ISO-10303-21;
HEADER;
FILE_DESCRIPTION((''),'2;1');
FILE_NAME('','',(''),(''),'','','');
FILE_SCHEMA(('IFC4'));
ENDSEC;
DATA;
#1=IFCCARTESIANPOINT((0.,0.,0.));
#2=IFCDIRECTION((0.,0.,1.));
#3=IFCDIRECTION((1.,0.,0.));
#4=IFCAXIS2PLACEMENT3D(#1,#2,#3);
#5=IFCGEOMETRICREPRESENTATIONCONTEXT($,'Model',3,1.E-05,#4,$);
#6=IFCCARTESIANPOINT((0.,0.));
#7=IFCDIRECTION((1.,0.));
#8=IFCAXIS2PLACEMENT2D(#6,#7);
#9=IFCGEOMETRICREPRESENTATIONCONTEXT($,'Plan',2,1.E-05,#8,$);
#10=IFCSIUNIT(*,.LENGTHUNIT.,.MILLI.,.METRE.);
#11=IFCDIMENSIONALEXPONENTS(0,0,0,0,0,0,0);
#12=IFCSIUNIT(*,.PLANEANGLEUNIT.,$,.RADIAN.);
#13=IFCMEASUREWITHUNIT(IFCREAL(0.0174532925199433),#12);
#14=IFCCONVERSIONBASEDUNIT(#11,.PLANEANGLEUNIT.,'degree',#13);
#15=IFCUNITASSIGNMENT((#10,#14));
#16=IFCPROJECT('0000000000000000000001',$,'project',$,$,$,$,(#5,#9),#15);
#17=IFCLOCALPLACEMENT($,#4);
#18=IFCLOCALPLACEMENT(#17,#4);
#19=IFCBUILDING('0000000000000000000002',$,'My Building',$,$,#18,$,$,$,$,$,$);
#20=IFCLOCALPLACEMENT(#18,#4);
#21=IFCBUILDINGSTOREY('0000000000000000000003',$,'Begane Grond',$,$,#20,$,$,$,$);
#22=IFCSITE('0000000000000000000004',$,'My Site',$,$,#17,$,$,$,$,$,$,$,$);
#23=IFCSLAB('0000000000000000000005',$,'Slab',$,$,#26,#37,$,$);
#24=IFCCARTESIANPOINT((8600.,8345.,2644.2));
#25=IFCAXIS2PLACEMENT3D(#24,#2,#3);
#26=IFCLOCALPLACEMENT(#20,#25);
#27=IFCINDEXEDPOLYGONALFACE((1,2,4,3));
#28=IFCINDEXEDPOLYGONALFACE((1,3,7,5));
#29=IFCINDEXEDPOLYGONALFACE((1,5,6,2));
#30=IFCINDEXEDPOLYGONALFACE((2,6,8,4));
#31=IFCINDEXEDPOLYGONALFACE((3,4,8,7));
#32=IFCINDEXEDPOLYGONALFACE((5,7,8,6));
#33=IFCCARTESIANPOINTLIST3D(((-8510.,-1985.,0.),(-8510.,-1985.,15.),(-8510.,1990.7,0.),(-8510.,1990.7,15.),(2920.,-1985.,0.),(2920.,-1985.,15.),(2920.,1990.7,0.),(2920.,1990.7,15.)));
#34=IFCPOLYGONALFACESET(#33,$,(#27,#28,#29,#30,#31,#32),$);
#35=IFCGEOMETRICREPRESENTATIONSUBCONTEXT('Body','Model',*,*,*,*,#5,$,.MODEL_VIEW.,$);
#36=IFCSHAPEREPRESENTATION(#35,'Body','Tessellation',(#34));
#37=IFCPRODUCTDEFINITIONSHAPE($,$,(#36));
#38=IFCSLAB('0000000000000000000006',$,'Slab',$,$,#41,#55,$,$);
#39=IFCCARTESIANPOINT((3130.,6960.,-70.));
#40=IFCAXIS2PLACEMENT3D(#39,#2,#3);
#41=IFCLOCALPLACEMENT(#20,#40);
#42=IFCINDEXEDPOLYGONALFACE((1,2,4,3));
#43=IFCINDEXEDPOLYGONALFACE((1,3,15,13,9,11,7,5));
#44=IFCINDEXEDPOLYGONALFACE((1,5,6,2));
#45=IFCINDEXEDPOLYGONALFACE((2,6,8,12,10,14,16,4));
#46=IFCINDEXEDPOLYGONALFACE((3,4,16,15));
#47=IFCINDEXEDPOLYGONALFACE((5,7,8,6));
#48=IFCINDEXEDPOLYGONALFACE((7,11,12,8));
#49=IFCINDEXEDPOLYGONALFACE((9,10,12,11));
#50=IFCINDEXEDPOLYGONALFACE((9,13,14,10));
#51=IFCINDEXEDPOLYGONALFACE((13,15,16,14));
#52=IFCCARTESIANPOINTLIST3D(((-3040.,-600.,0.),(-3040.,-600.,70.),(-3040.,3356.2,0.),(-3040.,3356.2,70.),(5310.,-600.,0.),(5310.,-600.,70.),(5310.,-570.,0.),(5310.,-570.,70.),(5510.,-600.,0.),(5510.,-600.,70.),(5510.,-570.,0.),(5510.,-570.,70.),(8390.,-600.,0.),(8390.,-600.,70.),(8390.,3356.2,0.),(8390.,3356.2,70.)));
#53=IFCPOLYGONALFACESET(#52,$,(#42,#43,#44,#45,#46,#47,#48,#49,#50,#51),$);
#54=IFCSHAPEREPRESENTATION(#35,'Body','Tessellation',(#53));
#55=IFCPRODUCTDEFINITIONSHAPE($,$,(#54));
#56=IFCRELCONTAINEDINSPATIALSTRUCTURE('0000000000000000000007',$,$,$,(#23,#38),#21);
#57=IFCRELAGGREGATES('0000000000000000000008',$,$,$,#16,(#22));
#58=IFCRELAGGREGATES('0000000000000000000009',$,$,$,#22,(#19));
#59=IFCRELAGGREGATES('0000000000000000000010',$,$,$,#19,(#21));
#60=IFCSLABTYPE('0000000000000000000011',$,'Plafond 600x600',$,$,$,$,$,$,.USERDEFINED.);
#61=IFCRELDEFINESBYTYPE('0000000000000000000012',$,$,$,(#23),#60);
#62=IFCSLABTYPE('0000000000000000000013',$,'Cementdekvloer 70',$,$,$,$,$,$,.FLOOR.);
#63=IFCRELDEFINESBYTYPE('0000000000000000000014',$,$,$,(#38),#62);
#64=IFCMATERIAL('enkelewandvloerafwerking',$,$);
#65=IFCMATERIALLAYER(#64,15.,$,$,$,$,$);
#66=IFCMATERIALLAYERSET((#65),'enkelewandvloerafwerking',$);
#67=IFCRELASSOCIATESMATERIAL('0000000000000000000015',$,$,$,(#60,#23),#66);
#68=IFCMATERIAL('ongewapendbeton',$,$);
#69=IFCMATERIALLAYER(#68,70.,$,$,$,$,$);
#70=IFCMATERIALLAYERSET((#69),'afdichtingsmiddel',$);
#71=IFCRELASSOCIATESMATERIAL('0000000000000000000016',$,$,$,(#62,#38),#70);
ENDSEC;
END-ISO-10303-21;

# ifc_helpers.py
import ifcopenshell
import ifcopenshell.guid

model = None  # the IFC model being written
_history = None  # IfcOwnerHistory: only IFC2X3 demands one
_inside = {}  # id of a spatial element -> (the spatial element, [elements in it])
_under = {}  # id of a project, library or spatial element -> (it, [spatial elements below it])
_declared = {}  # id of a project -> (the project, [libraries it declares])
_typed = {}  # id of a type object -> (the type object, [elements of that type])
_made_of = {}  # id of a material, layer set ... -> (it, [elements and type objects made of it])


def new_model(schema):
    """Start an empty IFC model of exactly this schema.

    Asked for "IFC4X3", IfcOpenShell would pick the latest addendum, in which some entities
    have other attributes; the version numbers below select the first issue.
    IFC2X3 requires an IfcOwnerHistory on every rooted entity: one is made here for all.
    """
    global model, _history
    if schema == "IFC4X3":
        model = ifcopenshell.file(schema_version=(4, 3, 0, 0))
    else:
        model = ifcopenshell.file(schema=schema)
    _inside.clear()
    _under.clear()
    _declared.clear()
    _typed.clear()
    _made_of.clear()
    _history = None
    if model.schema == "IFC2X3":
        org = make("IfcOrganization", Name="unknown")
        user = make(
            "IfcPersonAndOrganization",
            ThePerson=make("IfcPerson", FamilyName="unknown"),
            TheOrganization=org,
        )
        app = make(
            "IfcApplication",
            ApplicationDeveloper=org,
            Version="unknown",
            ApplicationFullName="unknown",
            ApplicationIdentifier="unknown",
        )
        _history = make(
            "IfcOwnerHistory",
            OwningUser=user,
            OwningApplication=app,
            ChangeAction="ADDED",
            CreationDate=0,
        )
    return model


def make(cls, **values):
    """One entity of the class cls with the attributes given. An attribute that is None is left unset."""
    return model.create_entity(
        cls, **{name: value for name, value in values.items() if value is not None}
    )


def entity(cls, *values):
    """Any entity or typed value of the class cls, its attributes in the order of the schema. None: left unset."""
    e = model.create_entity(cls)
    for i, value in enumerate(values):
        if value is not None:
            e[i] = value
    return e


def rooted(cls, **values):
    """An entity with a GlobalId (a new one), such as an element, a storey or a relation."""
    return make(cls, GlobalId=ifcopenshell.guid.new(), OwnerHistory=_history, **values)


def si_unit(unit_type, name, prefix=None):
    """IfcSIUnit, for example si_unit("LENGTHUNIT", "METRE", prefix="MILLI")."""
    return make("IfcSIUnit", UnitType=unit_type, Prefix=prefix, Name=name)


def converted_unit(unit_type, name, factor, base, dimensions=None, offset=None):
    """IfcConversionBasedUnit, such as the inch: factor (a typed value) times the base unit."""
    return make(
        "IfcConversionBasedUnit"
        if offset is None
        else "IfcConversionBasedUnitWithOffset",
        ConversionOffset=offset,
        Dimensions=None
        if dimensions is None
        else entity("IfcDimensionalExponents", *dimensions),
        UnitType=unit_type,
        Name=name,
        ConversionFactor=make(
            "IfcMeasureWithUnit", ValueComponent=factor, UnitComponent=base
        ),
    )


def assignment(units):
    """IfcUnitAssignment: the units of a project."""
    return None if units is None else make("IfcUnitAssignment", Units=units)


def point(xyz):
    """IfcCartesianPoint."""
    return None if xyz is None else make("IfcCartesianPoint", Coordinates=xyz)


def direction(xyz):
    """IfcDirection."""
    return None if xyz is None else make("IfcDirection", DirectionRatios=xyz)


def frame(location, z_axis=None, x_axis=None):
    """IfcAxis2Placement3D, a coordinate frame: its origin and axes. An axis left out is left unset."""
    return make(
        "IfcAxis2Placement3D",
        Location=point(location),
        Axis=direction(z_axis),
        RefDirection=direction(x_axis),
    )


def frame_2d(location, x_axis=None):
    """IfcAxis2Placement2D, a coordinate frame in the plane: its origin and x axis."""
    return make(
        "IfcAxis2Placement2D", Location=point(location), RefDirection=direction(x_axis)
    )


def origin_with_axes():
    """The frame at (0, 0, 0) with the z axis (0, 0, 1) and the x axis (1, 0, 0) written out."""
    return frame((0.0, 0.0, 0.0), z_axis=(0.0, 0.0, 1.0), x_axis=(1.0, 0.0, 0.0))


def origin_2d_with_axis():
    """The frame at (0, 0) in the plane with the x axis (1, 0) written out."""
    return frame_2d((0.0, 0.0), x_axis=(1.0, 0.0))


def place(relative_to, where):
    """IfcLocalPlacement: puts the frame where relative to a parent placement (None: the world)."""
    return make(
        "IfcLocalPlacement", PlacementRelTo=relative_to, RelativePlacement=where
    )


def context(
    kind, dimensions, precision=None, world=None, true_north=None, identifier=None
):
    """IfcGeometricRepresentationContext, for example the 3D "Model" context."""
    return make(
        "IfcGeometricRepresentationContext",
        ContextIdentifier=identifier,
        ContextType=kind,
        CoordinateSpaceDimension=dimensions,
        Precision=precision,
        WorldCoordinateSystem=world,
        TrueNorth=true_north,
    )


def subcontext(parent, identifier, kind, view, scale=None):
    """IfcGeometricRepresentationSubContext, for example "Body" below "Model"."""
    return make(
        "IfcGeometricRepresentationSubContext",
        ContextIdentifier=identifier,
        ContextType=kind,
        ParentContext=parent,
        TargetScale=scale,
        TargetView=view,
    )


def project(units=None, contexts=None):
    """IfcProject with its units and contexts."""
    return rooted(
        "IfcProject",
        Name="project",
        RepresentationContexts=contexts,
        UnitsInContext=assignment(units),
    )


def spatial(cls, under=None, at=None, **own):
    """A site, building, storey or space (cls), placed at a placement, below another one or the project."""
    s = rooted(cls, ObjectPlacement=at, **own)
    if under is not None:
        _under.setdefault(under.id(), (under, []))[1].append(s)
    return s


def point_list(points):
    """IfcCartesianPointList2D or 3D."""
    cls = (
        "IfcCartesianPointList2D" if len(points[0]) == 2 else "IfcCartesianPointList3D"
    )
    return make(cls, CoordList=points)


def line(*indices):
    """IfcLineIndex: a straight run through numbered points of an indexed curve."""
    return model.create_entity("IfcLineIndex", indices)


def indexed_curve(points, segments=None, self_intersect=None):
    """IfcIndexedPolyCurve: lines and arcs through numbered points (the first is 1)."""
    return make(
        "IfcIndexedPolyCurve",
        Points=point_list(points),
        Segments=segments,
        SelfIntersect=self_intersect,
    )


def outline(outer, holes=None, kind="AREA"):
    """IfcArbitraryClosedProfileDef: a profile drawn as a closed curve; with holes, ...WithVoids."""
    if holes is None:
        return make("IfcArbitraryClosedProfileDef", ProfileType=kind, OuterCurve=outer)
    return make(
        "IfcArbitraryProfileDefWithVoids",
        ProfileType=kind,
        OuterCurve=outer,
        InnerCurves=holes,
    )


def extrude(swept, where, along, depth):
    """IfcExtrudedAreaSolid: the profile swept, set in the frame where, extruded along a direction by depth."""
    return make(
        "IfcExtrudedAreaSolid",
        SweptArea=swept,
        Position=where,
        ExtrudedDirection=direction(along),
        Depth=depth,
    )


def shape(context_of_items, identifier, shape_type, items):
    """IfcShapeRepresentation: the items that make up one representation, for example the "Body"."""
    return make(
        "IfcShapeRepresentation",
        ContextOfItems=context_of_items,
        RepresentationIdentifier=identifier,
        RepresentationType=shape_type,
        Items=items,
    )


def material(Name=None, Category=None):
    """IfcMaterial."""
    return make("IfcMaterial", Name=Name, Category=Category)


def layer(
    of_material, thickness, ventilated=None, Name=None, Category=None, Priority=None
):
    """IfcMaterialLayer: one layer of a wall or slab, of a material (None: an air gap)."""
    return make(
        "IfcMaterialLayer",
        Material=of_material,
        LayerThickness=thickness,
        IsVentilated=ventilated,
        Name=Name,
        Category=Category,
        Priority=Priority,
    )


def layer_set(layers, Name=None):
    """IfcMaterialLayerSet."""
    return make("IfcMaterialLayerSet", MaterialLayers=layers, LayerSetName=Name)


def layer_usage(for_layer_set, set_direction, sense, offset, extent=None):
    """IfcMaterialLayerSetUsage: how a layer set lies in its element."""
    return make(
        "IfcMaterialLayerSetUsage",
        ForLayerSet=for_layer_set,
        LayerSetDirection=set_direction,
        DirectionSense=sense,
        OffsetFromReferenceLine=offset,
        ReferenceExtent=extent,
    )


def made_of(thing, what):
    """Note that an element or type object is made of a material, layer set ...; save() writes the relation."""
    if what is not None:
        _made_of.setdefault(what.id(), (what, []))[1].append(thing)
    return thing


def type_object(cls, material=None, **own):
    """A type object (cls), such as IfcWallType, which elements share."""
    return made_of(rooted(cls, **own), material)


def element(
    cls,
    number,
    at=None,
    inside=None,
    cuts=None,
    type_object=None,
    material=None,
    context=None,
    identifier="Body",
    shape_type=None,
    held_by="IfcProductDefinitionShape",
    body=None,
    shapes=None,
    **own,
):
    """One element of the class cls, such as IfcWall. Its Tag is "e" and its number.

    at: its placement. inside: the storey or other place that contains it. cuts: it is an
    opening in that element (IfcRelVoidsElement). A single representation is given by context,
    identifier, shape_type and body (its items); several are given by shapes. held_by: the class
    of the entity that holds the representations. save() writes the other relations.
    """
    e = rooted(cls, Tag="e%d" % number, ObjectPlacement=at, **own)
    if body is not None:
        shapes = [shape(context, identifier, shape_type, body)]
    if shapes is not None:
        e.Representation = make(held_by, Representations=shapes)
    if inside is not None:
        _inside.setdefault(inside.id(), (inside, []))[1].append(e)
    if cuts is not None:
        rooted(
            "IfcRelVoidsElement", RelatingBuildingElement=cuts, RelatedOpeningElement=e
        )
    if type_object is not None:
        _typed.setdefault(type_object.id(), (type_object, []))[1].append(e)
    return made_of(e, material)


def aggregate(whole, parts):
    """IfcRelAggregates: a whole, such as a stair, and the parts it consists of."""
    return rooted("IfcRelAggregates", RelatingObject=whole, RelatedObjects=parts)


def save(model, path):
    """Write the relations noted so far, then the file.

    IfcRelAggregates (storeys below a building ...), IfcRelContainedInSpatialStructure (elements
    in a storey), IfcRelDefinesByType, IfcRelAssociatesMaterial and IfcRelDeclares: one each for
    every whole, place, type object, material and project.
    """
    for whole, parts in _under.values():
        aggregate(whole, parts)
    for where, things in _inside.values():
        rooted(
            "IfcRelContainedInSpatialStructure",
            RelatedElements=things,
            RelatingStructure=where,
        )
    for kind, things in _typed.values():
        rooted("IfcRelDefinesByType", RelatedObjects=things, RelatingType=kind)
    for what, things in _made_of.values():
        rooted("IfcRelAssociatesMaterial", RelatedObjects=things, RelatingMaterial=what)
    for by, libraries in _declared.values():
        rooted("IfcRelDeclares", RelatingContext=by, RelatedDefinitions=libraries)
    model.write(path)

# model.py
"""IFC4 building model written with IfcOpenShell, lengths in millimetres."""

from ifc_helpers import new_model, entity, si_unit, converted_unit, frame, origin_with_axes, origin_2d_with_axis, place, context, subcontext, project, spatial, line, indexed_curve, outline, extrude, material, layer, layer_set, layer_usage, type_object, element, save


model = new_model("IFC4")

# Units and contexts
model_context = context("Model", 3, precision=1e-05, world=origin_with_axes())
plan_context = context("Plan", 2, precision=1e-05, world=origin_2d_with_axis())
body_context = subcontext(model_context, "Body", "Model", "MODEL_VIEW")
ifc_project = project(units=[si_unit("LENGTHUNIT", "METRE", prefix="MILLI"), converted_unit("PLANEANGLEUNIT", "degree", entity("IfcReal", 0.0174532925199433), si_unit("PLANEANGLEUNIT", "RADIAN"), dimensions=[0, 0, 0, 0, 0, 0, 0])], contexts=[model_context, plan_context])

# Site, building, storey
site_placement = place(None, origin_with_axes())
site = spatial("IfcSite", under=ifc_project, at=site_placement, Name="My Site")
building_placement = place(site_placement, origin_with_axes())
building = spatial("IfcBuilding", under=site, at=building_placement, Name="My Building")
storey_placement = place(building_placement, origin_with_axes())
storey = spatial("IfcBuildingStorey", under=building, at=storey_placement, Name="Begane Grond")

# Slabs
ifc_material_1 = material(Name="enkelewandvloerafwerking")
ifc_layer_1 = layer(ifc_material_1, 15.0)
ifc_layer_set_1 = layer_set([ifc_layer_1], Name="enkelewandvloerafwerking")
ifc_layer_usage_1 = layer_usage(ifc_layer_set_1, "AXIS3", "POSITIVE", 0.0)
slab_type_1 = type_object("IfcSlabType", Name="Plafond 600x600", PredefinedType="USERDEFINED", material=ifc_layer_set_1)
slab_1_placement = place(storey_placement, frame((8600.0, 8345.0, 2644.2), z_axis=(0.0, 0.0, 1.0), x_axis=(1.0, 0.0, 0.0)))
element("IfcSlab", 1, at=slab_1_placement, inside=storey, type_object=slab_type_1, material=ifc_layer_usage_1, Name="Slab", context=body_context, shape_type="SweptSolid", body=[
    extrude(outline(indexed_curve([(2920.0, -1985.0), (-8510.0, -1985.0), (-8510.0, 1990.7), (2920.0, 1990.7)], segments=[line(4, 1), line(1, 2), line(2, 3), line(3, 4)], self_intersect=False)), None, (0.0, 0.0, 1.0), 15.0),
])
ifc_material_2 = material(Name="ongewapendbeton")
ifc_layer_2 = layer(ifc_material_2, 70.0)
ifc_layer_set_2 = layer_set([ifc_layer_2], Name="afdichtingsmiddel")
ifc_layer_usage_2 = layer_usage(ifc_layer_set_2, "AXIS3", "POSITIVE", 0.0)
slab_type_2 = type_object("IfcSlabType", Name="Cementdekvloer 70", PredefinedType="FLOOR", material=ifc_layer_set_2)
slab_2_placement = place(storey_placement, frame((3130.0, 6960.0, -70.0), z_axis=(0.0, 0.0, 1.0), x_axis=(1.0, 0.0, 0.0)))
element("IfcSlab", 2, at=slab_2_placement, inside=storey, type_object=slab_type_2, material=ifc_layer_usage_2, Name="Slab", context=body_context, shape_type="SweptSolid", body=[
    extrude(outline(indexed_curve([(-3040.0, -600.0), (-3040.0, 3356.2), (8390.0, 3356.2), (8390.0, -600.0), (5510.0, -600.0), (5510.0, -570.0), (5310.0, -570.0), (5310.0, -600.0)], segments=[line(5, 6), line(6, 7), line(7, 8), line(8, 1), line(1, 2), line(2, 3), line(3, 4), line(4, 5)], self_intersect=False)), None, (0.0, 0.0, 1.0), 70.0),
])

save(model, "model.ifc")
